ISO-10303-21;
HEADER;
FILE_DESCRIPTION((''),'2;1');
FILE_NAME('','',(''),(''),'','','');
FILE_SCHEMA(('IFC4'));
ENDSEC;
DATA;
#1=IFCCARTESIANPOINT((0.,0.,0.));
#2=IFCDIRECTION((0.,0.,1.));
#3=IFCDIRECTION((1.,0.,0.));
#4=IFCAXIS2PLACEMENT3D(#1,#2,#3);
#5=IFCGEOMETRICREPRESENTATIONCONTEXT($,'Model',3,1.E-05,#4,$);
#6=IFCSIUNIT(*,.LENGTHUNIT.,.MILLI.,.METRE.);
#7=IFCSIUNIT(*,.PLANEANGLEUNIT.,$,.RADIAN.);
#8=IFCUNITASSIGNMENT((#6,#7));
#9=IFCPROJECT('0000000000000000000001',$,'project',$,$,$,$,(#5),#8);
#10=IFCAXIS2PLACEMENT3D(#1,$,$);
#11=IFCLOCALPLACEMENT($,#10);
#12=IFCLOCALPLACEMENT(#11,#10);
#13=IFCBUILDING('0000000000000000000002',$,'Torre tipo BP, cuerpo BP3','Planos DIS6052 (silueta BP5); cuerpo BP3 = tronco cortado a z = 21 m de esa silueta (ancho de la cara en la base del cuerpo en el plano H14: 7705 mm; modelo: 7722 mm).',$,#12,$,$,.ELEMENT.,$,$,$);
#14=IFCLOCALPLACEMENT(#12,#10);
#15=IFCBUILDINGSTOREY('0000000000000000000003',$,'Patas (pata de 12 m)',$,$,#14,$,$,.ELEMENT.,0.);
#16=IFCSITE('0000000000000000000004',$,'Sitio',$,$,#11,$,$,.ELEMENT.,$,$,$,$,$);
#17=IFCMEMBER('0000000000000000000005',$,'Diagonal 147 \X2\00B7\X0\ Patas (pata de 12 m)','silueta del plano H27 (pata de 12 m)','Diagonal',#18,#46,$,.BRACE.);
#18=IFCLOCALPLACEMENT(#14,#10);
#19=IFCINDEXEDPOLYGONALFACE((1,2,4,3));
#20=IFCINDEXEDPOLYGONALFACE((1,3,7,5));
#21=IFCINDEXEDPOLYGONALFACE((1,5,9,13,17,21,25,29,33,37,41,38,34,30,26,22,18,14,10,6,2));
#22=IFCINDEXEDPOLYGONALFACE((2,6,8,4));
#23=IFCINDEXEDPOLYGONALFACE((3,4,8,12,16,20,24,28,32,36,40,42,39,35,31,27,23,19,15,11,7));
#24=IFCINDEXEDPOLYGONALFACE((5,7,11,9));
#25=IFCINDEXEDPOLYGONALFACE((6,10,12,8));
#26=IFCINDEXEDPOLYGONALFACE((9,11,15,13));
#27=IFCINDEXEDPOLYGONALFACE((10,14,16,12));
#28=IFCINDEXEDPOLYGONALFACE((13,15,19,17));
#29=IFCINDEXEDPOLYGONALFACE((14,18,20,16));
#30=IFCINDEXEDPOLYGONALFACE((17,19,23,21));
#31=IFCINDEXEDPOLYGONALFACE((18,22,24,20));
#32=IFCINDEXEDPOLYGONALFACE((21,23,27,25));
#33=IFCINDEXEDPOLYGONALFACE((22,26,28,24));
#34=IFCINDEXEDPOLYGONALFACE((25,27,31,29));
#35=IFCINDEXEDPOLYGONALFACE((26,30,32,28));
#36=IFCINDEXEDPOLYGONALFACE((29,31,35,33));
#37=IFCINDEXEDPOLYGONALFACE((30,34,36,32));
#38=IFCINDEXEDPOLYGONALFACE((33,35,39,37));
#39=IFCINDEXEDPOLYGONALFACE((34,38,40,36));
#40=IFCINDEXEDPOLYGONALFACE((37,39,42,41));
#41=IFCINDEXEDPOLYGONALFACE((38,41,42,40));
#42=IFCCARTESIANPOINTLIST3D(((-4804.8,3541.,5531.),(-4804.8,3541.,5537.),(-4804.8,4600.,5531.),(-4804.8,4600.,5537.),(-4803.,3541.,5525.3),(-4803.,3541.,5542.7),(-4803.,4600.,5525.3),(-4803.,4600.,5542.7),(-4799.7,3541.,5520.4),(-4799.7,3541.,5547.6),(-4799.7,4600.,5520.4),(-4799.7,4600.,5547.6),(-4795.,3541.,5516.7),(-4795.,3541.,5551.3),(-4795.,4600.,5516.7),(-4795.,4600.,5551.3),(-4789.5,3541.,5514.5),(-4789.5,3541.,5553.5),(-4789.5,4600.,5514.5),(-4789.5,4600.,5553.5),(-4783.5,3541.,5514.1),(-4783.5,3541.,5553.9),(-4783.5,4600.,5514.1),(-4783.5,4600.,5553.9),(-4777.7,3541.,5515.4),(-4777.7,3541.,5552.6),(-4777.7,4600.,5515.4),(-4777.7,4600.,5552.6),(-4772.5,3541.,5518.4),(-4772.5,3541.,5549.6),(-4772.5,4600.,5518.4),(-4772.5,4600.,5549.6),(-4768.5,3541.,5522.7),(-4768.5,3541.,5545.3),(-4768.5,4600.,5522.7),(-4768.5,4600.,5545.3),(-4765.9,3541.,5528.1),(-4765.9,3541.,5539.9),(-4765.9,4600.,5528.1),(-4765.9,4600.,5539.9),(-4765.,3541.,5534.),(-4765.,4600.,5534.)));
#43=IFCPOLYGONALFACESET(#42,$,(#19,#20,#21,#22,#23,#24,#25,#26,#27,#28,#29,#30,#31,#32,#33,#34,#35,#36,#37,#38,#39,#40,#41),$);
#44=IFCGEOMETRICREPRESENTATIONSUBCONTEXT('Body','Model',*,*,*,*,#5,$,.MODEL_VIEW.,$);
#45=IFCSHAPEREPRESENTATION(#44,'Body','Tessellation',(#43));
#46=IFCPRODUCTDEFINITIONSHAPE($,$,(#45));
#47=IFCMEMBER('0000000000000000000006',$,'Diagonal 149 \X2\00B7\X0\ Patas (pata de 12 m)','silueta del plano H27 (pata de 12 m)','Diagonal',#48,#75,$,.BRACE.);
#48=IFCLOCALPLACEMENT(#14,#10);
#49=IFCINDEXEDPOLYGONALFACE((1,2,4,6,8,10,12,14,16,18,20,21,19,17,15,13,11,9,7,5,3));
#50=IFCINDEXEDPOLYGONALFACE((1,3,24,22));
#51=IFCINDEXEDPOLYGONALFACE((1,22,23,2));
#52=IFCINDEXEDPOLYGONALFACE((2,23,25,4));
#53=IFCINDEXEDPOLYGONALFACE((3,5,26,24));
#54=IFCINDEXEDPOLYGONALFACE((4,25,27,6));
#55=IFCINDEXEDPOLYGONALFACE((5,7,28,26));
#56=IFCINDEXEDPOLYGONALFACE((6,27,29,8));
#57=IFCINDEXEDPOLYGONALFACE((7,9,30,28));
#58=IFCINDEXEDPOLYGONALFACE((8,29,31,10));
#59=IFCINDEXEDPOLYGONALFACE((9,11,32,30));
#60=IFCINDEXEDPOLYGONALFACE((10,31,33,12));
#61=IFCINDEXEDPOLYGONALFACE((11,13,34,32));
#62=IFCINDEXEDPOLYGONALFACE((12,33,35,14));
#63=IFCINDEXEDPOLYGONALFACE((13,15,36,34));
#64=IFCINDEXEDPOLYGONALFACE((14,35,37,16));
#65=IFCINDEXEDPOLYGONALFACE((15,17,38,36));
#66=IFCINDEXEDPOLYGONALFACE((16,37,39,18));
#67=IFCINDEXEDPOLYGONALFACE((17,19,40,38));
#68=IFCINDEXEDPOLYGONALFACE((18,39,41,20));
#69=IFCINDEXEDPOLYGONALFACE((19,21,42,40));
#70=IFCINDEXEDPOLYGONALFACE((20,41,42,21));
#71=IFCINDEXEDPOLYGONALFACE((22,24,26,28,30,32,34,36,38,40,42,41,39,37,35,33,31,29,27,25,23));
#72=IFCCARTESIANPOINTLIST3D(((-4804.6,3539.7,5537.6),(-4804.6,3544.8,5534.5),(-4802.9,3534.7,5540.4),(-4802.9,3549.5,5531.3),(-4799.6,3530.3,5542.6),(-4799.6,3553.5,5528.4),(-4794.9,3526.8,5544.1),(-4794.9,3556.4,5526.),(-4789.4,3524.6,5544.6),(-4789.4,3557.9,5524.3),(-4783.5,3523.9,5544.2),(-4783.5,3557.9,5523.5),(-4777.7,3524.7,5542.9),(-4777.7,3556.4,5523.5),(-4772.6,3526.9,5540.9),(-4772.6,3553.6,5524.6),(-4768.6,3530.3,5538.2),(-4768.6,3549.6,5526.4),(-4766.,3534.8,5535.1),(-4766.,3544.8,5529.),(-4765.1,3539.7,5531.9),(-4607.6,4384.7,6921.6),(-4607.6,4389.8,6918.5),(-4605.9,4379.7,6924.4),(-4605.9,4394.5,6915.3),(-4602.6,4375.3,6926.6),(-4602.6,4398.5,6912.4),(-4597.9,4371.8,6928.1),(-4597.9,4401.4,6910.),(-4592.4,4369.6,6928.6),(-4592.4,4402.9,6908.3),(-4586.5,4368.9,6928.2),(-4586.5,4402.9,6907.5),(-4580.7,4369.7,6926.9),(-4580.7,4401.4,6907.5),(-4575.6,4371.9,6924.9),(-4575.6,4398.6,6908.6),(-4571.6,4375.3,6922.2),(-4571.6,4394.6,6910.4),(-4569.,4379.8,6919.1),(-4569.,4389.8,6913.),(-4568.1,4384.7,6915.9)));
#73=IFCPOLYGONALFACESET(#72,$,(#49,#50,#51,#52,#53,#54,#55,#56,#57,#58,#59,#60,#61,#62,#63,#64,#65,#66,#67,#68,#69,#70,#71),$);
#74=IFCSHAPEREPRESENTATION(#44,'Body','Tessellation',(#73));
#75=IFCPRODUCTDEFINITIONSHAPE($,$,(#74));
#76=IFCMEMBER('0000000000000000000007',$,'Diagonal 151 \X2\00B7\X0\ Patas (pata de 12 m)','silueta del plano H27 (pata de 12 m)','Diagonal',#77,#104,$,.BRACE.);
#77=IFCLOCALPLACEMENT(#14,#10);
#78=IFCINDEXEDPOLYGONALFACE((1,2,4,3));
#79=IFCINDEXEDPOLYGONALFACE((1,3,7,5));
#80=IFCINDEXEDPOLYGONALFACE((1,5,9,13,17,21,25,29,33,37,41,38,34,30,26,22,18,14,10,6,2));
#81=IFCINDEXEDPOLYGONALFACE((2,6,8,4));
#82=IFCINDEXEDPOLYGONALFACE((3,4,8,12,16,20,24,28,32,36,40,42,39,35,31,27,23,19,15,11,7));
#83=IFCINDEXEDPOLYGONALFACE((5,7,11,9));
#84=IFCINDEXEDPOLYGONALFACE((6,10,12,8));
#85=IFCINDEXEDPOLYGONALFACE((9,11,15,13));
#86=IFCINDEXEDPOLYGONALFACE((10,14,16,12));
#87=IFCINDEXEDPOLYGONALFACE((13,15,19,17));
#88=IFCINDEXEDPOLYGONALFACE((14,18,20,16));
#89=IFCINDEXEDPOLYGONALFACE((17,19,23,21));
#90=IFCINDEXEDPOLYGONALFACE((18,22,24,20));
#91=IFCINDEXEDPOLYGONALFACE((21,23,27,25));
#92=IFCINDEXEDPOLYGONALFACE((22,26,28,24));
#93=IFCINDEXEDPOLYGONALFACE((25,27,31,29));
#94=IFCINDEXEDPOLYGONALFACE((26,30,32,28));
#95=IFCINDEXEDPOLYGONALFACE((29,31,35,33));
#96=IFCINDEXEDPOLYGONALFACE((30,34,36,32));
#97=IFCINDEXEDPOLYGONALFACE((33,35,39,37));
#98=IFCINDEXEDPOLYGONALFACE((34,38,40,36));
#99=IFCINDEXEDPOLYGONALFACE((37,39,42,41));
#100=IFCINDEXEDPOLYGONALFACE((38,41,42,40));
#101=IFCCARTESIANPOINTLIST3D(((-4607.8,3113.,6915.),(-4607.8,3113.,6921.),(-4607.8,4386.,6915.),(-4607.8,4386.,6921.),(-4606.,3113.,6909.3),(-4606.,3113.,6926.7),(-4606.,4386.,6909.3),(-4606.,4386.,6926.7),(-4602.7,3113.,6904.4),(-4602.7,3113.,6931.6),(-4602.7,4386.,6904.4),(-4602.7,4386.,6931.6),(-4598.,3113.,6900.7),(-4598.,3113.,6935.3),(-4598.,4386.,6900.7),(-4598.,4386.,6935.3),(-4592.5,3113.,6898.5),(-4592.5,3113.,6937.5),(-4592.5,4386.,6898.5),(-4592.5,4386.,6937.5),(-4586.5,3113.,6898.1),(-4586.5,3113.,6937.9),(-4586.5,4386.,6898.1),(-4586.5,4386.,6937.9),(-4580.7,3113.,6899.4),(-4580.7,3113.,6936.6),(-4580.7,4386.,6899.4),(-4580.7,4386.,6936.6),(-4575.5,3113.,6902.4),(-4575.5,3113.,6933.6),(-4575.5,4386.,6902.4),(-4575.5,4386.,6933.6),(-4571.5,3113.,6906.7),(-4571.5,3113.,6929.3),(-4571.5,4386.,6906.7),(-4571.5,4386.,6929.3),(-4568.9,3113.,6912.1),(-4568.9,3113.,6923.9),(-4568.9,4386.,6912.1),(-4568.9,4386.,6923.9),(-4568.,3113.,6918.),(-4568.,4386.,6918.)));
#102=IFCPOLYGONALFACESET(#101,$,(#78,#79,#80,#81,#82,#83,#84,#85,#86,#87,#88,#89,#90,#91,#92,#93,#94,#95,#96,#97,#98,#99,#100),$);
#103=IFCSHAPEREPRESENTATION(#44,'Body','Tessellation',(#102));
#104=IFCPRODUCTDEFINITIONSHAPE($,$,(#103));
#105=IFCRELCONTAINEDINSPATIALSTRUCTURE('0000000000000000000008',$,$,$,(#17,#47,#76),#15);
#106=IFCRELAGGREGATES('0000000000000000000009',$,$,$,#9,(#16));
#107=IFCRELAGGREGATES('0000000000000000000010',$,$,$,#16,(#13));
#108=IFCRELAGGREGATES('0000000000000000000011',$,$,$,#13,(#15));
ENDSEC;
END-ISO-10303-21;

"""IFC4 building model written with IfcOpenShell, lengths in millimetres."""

from ifc_helpers import new_model, si_unit, frame, origin, origin_with_axes, place, context, subcontext, project, spatial, circle, extrude, element, save


model = new_model("IFC4")

# Units and contexts
model_context = context("Model", 3, precision=1e-05, world=origin_with_axes())
body_context = subcontext(model_context, "Body", "Model", "MODEL_VIEW")
ifc_project = project(units=[si_unit("LENGTHUNIT", "METRE", prefix="MILLI"), si_unit("PLANEANGLEUNIT", "RADIAN")], contexts=[model_context])

# Site, building, storey
site_placement = place(None, origin())
site = spatial("IfcSite", under=ifc_project, at=site_placement, Name="Sitio", CompositionType="ELEMENT")
building_placement = place(site_placement, origin())
building = spatial("IfcBuilding", under=site, at=building_placement, Name="Torre tipo BP, cuerpo BP3", Description="Planos DIS6052 (silueta BP5); cuerpo BP3 = tronco cortado a z = 21 m de esa silueta (ancho de la cara en la base del cuerpo en el plano H14: 7705 mm; modelo: 7722 mm).", CompositionType="ELEMENT")
storey_placement = place(building_placement, origin())
storey = spatial("IfcBuildingStorey", under=building, at=storey_placement, Name="Patas (pata de 12 m)", CompositionType="ELEMENT", Elevation=0.0)

# Members
member_1_placement = place(storey_placement, frame((-4785.0, 4600.0, 5534.0), z_axis=(0.0, -1.0, 0.0), x_axis=(1.0, 0.0, 0.0)))
element("IfcMember", 1, at=member_1_placement, inside=storey, Name="Diagonal 147 · Patas (pata de 12 m)", Description="silueta del plano H27 (pata de 12 m)", ObjectType="Diagonal", PredefinedType="BRACE", context=body_context, shape_type="SweptSolid", body=[
    extrude(circle(Radius=20.0), None, (0.0, 0.0, 1.0), 1059.0),
])
member_2_placement = place(storey_placement, frame((-4785.0, 3541.0, 5534.0), z_axis=(0.120601, 0.517297, 0.847266), x_axis=(0.992701, -0.062845, -0.102932)))
element("IfcMember", 2, at=member_2_placement, inside=storey, Name="Diagonal 149 · Patas (pata de 12 m)", Description="silueta del plano H27 (pata de 12 m)", ObjectType="Diagonal", PredefinedType="BRACE", context=body_context, shape_type="SweptSolid", body=[
    extrude(circle(Radius=20.0), None, (0.0, 0.0, 1.0), 1633.5),
])
member_3_placement = place(storey_placement, frame((-4588.0, 4386.0, 6918.0), z_axis=(0.0, -1.0, 0.0), x_axis=(1.0, 0.0, 0.0)))
element("IfcMember", 3, at=member_3_placement, inside=storey, Name="Diagonal 151 · Patas (pata de 12 m)", Description="silueta del plano H27 (pata de 12 m)", ObjectType="Diagonal", PredefinedType="BRACE", context=body_context, shape_type="SweptSolid", body=[
    extrude(circle(Radius=20.0), None, (0.0, 0.0, 1.0), 1273.0),
])

save(model, "model.ifc")
